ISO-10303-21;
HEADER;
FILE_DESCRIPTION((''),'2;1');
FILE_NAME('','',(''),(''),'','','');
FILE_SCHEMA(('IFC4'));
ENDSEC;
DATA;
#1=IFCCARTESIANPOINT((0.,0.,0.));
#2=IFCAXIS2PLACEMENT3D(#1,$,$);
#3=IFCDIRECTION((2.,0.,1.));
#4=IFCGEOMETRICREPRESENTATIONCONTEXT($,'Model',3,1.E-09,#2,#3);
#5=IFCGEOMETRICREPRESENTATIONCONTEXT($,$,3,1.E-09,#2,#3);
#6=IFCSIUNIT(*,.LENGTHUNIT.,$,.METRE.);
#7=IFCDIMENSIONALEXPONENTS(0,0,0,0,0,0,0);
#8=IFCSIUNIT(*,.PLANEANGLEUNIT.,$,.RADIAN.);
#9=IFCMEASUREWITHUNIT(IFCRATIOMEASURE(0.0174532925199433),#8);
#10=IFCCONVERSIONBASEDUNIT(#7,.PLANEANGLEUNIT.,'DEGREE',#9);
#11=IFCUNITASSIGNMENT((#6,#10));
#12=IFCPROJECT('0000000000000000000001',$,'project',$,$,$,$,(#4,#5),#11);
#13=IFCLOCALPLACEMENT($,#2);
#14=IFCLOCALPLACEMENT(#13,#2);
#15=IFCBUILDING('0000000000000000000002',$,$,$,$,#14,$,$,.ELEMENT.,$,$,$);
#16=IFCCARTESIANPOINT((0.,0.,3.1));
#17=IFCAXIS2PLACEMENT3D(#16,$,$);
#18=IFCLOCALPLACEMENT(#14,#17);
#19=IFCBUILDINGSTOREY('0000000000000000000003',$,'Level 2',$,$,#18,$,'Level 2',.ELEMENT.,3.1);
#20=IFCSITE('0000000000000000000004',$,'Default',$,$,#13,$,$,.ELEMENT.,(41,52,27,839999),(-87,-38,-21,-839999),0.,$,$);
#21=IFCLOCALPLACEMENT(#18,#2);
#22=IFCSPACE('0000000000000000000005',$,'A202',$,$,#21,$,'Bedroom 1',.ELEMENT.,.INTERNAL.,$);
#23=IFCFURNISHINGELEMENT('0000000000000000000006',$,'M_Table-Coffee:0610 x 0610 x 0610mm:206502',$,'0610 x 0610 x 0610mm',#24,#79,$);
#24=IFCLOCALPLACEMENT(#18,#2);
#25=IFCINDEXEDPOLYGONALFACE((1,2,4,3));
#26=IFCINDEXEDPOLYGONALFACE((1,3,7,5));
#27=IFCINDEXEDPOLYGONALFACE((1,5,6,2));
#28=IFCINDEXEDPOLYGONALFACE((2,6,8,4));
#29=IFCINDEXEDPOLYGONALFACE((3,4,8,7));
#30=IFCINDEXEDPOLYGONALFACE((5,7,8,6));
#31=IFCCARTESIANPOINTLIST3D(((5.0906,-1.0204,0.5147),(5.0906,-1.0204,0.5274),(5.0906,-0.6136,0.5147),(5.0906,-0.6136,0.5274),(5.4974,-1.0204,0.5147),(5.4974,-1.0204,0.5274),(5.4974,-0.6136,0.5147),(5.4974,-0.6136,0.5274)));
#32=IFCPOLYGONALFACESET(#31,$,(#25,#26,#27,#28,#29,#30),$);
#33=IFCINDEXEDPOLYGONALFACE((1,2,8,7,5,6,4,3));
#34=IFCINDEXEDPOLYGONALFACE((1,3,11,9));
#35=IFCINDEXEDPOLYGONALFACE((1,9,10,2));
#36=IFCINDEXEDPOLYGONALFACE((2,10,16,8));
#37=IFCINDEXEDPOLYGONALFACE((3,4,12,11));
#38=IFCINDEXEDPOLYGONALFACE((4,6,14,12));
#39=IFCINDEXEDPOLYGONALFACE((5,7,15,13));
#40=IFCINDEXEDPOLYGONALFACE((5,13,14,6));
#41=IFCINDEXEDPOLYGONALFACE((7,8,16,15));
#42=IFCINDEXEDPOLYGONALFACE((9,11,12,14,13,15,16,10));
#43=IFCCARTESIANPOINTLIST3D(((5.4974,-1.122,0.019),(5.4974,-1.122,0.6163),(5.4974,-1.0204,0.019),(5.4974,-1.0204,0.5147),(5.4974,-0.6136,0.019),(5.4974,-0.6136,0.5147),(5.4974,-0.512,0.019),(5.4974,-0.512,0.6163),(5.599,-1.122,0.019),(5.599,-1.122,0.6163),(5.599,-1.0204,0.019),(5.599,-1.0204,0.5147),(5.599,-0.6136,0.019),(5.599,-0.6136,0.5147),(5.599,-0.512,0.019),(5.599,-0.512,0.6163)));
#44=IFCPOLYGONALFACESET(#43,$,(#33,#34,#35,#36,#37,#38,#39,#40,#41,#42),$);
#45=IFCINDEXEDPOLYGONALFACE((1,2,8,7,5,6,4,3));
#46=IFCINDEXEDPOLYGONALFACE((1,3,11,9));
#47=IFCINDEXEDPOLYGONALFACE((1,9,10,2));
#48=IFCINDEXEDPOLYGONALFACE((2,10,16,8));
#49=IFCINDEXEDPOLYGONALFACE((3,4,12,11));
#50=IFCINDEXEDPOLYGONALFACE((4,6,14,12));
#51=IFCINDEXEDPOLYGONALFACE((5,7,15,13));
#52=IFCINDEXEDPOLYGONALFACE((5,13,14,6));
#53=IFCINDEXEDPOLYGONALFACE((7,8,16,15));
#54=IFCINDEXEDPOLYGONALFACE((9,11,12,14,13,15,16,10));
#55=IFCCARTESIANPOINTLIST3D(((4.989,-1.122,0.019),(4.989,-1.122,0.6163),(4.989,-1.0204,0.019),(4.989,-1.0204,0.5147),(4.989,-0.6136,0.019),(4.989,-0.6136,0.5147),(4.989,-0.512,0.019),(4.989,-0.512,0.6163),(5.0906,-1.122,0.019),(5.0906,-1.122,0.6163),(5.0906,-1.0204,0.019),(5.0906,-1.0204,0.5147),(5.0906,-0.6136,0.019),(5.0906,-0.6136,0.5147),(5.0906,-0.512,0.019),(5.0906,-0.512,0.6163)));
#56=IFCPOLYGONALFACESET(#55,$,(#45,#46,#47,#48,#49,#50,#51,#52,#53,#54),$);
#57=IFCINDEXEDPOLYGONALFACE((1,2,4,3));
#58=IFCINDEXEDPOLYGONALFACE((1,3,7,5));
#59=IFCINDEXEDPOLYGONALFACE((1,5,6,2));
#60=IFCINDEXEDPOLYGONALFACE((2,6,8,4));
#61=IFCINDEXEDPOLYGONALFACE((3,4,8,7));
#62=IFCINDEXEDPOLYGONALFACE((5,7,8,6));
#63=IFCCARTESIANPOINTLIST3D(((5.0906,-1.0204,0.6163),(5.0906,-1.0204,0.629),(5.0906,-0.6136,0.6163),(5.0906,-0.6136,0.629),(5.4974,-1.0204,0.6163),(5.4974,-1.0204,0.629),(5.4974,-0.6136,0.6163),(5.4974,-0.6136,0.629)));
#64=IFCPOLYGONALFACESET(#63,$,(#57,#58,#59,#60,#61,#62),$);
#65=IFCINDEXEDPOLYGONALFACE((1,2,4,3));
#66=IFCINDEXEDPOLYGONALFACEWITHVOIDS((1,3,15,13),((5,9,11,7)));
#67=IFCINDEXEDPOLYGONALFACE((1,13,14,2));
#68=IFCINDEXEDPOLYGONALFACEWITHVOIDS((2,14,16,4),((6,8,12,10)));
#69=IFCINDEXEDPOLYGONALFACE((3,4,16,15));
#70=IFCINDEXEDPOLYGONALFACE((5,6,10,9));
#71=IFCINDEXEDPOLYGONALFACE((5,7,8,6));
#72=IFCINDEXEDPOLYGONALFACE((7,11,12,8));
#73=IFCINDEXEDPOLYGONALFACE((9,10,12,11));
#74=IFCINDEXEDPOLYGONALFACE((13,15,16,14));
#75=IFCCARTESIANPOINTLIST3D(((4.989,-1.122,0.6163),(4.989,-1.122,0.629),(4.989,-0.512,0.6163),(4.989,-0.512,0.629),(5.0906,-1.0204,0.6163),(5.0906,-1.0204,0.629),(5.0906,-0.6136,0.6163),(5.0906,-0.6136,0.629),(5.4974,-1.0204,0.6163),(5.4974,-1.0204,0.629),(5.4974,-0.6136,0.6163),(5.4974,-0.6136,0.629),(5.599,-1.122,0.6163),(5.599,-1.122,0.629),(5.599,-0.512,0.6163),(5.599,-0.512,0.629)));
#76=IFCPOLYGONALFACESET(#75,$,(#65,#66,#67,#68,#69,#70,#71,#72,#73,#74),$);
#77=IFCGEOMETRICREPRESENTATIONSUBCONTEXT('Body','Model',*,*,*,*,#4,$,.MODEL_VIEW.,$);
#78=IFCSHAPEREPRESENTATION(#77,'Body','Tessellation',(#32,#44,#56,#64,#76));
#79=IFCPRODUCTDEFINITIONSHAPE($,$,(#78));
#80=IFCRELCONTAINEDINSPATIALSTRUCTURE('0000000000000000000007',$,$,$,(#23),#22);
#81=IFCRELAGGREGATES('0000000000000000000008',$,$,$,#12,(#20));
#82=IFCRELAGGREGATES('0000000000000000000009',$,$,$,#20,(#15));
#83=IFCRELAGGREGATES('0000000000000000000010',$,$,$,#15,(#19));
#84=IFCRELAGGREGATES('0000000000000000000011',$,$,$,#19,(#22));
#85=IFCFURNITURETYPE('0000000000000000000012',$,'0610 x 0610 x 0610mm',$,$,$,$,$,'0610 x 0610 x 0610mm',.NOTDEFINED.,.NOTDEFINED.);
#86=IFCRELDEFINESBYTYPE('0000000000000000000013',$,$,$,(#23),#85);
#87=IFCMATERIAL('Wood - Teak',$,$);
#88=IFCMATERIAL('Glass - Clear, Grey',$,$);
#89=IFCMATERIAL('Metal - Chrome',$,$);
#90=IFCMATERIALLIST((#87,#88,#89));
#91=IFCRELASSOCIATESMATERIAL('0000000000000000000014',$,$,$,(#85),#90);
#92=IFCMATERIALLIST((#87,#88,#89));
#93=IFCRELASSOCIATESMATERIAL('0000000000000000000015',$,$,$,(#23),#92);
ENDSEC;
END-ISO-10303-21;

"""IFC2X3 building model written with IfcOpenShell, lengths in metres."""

from ifc_helpers import new_model, entity, si_unit, converted_unit, direction, frame, origin, origin_2d_with_axis, place, context, subcontext, project, spatial, polyline, rectangle, outline, extrude, source, transform, mapped, material, material_list, type_object, type_shapes, element, save


model = new_model("IFC2X3")

# Units and contexts
model_context = context("Model", 3, precision=1e-09, world=origin(), true_north=direction((2.0, 0.0, 1.0)))
context_of_model = context(None, 3, precision=1e-09, world=origin(), true_north=direction((2.0, 0.0, 1.0)))
body_context = subcontext(model_context, "Body", "Model", "MODEL_VIEW")
ifc_project = project(units=[si_unit("LENGTHUNIT", "METRE"), converted_unit("PLANEANGLEUNIT", "DEGREE", entity("IfcRatioMeasure", 0.0174532925199433), si_unit("PLANEANGLEUNIT", "RADIAN"), dimensions=[0, 0, 0, 0, 0, 0, 0])], contexts=[model_context, context_of_model])

# Site, building, storey
site_placement = place(None, origin())
site = spatial("IfcSite", under=ifc_project, at=site_placement, Name="Default", CompositionType="ELEMENT", RefLatitude=(41, 52, 27, 839999), RefLongitude=(-87, -38, -21, -839999), RefElevation=0.0)
building_placement = place(site_placement, origin())
building = spatial("IfcBuilding", under=site, at=building_placement, CompositionType="ELEMENT")
storey_placement = place(building_placement, frame((0.0, 0.0, 3.1)))
storey = spatial("IfcBuildingStorey", under=building, at=storey_placement, Name="Level 2", LongName="Level 2", CompositionType="ELEMENT", Elevation=3.1)

# Shared definitions
ifc_material_1 = material(Name="Wood - Teak")
ifc_material_2 = material(Name="Glass - Clear, Grey")
ifc_material_3 = material(Name="Metal - Chrome")
ifc_material_list_1 = material_list([ifc_material_1, ifc_material_2, ifc_material_3])
furniture_type_1 = type_object("IfcFurnitureType", Name="0610 x 0610 x 0610mm", ElementType="0610 x 0610 x 0610mm", AssemblyPlace="NOTDEFINED", material=ifc_material_list_1)
shared_shape_1 = source(origin(), body_context, "Body", "SweptSolid", [
    extrude(rectangle(XDim=0.4068, YDim=0.4068, at=origin_2d_with_axis()), frame((0.0183, 0.0952, 0.4957), z_axis=(0.0, 0.0, 1.0), x_axis=(-1.0, 0.0, 0.0)), (0.0, 0.0, 1.0), 0.0127),
    extrude(outline(polyline([(-0.2732, -0.305), (0.324, -0.305), (0.324, 0.305), (-0.2732, 0.305), (-0.2732, 0.2034), (0.2225, 0.2034), (0.2225, -0.2034), (-0.2732, -0.2034), (-0.2732, -0.305)])), frame((0.2217, 0.0952, 0.2732), z_axis=(1.0, 0.0, 0.0), x_axis=(0.0, 0.0, 1.0)), (0.0, 0.0, 1.0), 0.1016),
    extrude(outline(polyline([(-0.305, -0.3241), (0.305, -0.3241), (0.305, 0.2733), (0.2034, 0.2733), (0.2034, -0.2224), (-0.2034, -0.2224), (-0.2034, 0.2733), (-0.305, 0.2733), (-0.305, -0.3241)])), frame((-0.2867, 0.0952, 0.2733), z_axis=(1.0, 0.0, 0.0), x_axis=(0.0, -1.0, 0.0)), (0.0, 0.0, 1.0), 0.1016),
    extrude(rectangle(XDim=0.4068, YDim=0.4068, at=origin_2d_with_axis()), frame((0.0183, 0.0952, 0.5973), z_axis=(0.0, 0.0, 1.0), x_axis=(-1.0, 0.0, 0.0)), (0.0, 0.0, 1.0), 0.0127),
    extrude(outline(polyline([(-0.305, -0.305), (0.305, -0.305), (0.305, 0.305), (-0.305, 0.305), (-0.305, -0.305)]), holes=[polyline([(-0.2034, -0.2034), (-0.2034, 0.2034), (0.2034, 0.2034), (0.2034, -0.2034), (-0.2034, -0.2034)])]), frame((0.0183, 0.0952, 0.5973), z_axis=(0.0, 0.0, 1.0), x_axis=(-1.0, 0.0, 0.0)), (0.0, 0.0, 1.0), 0.0127),
])
type_shapes(furniture_type_1, [shared_shape_1])

# Shared definitions
space_1_placement = place(storey_placement, origin())
space_1 = spatial("IfcSpace", under=storey, at=space_1_placement, Name="A202", LongName="Bedroom 1", CompositionType="ELEMENT", InteriorOrExteriorSpace="INTERNAL")

# Furnishing element
ifc_material_list_2 = material_list([ifc_material_1, ifc_material_2, ifc_material_3])
furnishing_1_placement = place(space_1_placement, frame((5.2757, -0.9122, 0.019)))
element("IfcFurnishingElement", 1, at=furnishing_1_placement, inside=space_1, type_object=furniture_type_1, material=ifc_material_list_2, Name="M_Table-Coffee:0610 x 0610 x 0610mm:206502", ObjectType="0610 x 0610 x 0610mm", context=body_context, shape_type="MappedRepresentation", body=[
    mapped(shared_shape_1, transform((0.0, 0.0, 0.0), scale=1.0)),
])

save(model, "model.ifc")
